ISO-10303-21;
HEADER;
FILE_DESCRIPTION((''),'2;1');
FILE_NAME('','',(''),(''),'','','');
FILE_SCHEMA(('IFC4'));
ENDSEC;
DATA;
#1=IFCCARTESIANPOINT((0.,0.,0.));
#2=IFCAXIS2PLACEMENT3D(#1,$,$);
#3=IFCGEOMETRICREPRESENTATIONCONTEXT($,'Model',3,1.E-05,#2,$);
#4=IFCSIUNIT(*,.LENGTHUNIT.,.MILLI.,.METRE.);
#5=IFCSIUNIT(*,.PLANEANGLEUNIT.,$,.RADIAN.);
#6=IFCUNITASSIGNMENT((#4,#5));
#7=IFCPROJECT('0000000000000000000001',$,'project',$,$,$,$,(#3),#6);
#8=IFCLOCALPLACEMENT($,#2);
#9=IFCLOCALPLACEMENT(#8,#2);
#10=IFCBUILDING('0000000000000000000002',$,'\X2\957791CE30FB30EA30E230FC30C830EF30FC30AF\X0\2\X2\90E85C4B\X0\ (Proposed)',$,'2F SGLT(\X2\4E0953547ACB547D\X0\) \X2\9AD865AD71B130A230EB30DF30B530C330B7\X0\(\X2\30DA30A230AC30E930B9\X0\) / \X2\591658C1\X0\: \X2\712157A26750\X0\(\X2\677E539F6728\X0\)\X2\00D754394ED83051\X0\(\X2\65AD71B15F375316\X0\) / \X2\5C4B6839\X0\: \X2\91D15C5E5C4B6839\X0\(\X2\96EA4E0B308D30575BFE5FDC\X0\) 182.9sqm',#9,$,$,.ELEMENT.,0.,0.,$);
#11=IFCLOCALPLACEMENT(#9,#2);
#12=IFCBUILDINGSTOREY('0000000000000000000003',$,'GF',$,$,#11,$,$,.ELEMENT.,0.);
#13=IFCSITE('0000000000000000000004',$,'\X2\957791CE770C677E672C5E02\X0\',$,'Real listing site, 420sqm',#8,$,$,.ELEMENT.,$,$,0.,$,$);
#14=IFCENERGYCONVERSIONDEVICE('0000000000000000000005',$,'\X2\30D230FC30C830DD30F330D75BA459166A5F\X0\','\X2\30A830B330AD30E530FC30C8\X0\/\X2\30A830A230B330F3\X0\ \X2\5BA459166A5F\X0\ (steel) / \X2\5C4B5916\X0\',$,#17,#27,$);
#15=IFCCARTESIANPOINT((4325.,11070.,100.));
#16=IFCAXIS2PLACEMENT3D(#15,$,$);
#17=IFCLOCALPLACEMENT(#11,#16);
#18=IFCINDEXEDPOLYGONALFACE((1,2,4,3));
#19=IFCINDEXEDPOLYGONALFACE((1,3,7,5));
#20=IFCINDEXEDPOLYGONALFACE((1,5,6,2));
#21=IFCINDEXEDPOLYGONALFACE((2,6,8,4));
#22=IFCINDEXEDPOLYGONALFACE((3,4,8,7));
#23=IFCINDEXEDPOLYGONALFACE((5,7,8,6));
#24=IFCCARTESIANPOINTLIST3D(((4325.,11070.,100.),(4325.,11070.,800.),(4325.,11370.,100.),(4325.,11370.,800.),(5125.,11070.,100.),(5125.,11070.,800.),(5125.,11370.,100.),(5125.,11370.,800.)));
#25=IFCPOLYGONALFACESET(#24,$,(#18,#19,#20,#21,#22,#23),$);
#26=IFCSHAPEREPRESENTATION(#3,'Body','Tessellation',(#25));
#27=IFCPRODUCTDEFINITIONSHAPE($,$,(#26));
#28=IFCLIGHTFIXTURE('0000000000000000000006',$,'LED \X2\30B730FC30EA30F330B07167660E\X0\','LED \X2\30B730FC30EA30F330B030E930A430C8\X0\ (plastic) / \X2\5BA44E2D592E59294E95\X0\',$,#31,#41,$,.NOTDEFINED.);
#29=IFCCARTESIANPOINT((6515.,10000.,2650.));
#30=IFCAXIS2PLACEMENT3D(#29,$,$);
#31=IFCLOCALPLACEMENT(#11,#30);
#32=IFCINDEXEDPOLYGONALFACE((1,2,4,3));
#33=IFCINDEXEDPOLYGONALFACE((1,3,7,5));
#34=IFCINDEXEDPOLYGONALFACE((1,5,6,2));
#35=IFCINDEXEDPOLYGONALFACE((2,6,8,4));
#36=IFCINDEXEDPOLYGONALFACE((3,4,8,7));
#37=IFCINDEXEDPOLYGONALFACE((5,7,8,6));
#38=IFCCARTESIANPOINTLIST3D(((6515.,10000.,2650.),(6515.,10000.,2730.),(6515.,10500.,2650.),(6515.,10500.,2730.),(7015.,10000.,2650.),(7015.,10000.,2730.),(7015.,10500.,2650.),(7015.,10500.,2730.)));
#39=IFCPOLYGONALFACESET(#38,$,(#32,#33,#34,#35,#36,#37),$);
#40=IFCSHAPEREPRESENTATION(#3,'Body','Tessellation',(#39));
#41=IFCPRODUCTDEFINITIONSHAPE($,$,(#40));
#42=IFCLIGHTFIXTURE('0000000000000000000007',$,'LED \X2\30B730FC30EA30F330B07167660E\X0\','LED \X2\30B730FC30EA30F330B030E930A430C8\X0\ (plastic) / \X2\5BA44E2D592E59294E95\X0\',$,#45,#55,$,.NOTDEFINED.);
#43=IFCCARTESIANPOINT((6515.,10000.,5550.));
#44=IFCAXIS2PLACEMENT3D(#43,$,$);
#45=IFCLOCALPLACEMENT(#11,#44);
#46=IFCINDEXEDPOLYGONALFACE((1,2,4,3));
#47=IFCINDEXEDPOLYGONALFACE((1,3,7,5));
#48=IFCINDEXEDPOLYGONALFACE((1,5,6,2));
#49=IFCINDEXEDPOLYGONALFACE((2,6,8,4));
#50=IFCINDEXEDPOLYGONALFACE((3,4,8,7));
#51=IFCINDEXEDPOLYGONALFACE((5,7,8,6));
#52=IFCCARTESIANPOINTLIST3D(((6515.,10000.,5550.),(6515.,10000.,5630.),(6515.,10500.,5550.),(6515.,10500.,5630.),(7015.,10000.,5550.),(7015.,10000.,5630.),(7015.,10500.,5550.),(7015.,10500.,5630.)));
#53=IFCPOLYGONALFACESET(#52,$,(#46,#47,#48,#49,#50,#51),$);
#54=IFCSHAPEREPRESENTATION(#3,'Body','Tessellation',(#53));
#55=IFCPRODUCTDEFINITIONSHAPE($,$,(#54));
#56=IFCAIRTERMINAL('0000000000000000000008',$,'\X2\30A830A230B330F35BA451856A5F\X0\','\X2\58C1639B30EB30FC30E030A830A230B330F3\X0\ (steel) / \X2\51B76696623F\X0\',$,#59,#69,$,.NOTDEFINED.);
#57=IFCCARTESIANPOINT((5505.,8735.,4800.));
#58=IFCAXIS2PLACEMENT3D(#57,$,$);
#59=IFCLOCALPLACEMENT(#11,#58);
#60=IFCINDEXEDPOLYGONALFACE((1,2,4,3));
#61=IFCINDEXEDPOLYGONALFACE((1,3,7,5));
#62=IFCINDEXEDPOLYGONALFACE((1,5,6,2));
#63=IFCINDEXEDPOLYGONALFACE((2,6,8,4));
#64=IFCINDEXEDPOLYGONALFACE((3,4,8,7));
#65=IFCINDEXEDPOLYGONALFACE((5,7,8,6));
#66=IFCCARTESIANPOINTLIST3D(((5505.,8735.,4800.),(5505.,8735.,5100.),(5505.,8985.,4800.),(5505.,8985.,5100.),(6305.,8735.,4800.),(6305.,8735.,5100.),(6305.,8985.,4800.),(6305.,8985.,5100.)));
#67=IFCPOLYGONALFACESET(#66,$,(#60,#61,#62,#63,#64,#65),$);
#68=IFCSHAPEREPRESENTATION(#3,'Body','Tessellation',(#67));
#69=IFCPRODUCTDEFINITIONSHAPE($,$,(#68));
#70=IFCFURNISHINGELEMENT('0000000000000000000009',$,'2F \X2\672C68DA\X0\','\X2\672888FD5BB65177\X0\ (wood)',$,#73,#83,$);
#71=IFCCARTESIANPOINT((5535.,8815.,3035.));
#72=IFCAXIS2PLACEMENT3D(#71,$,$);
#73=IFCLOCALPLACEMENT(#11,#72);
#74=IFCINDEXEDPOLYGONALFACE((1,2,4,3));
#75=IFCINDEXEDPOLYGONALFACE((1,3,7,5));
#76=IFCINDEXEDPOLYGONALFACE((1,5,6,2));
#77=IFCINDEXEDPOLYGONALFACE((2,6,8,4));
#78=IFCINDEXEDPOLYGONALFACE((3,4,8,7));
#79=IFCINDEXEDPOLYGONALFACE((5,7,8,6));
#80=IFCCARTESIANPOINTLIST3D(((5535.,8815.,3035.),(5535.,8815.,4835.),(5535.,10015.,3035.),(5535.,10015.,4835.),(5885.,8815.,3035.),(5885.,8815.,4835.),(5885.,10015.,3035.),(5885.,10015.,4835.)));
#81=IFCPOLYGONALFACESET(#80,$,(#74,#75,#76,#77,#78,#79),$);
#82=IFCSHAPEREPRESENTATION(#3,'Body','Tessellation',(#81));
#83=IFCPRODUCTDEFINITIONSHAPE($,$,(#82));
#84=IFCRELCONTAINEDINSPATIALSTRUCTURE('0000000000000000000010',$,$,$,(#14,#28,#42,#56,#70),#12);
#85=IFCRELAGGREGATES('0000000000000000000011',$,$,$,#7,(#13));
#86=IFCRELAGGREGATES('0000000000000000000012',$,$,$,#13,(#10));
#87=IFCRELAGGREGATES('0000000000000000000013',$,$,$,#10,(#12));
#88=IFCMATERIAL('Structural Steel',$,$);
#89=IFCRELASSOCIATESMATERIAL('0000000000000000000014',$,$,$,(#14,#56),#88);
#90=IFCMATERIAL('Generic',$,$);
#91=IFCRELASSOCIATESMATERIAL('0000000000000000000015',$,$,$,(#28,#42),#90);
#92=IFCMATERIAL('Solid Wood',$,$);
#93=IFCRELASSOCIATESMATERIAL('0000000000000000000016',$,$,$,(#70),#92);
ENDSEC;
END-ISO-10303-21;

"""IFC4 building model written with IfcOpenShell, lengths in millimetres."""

from ifc_helpers import new_model, si_unit, frame, frame_2d, origin, place, context, project, spatial, rectangle, extrude, material, element, save


model = new_model("IFC4")

# Units and contexts
model_context = context("Model", 3, precision=1e-05, world=origin())
ifc_project = project(units=[si_unit("LENGTHUNIT", "METRE", prefix="MILLI"), si_unit("PLANEANGLEUNIT", "RADIAN")], contexts=[model_context])

# Site, building, storey
site_placement = place(None, origin())
site = spatial("IfcSite", under=ifc_project, at=site_placement, Name="長野県松本市", ObjectType="Real listing site, 420sqm", CompositionType="ELEMENT", RefElevation=0.0)
building_placement = place(site_placement, origin())
building = spatial("IfcBuilding", under=site, at=building_placement, Name="長野・リモートワーク2部屋 (Proposed)", ObjectType="2F SGLT(三協立命) 高断熱アルミサッシ(ペアガラス) / 外壁: 無垢材(松原木)×吹付け(断熱強化) / 屋根: 金属屋根(雪下ろし対応) 182.9sqm", CompositionType="ELEMENT", ElevationOfRefHeight=0.0, ElevationOfTerrain=0.0)
storey_placement = place(building_placement, origin())
storey = spatial("IfcBuildingStorey", under=building, at=storey_placement, Name="GF", CompositionType="ELEMENT", Elevation=0.0)

# Shared definitions
ifc_material_1 = material(Name="Solid Wood")

# Shared definitions
ifc_material_2 = material(Name="Structural Steel")

# Shared definitions
ifc_material_3 = material(Name="Generic")

# Energy conversion device
energy_conversion_device_placement = place(storey_placement, frame((4325.0, 11070.0, 100.0)))
element("IfcEnergyConversionDevice", 1, at=energy_conversion_device_placement, inside=storey, material=ifc_material_2, Name="ヒートポンプ室外機", Description="エコキュート/エアコン 室外機 (steel) / 屋外", context=model_context, shape_type="SweptSolid", body=[
    extrude(rectangle(XDim=800.0, YDim=300.0, at=frame_2d((400.0, 150.0))), frame((4325.0, 11070.0, 100.0)), (0.0, 0.0, 1.0), 700.0),
])

# Light fixtures
light_fixture_1_placement = place(storey_placement, frame((6515.0, 10000.0, 2650.0)))
element("IfcLightFixture", 2, at=light_fixture_1_placement, inside=storey, material=ifc_material_3, Name="LED シーリング照明", Description="LED シーリングライト (plastic) / 室中央天井", PredefinedType="NOTDEFINED", context=model_context, shape_type="SweptSolid", body=[
    extrude(rectangle(XDim=500.0, YDim=500.0, at=frame_2d((250.0, 250.0))), frame((6515.0, 10000.0, 2650.0)), (0.0, 0.0, 1.0), 80.0),
])
light_fixture_2_placement = place(storey_placement, frame((6515.0, 10000.0, 5550.0)))
element("IfcLightFixture", 3, at=light_fixture_2_placement, inside=storey, material=ifc_material_3, Name="LED シーリング照明", Description="LED シーリングライト (plastic) / 室中央天井", PredefinedType="NOTDEFINED", context=model_context, shape_type="SweptSolid", body=[
    extrude(rectangle(XDim=500.0, YDim=500.0, at=frame_2d((250.0, 250.0))), frame((6515.0, 10000.0, 5550.0)), (0.0, 0.0, 1.0), 80.0),
])

# Air terminal
air_terminal_placement = place(storey_placement, frame((5505.0, 8735.0, 4800.0)))
element("IfcAirTerminal", 4, at=air_terminal_placement, inside=storey, material=ifc_material_2, Name="エアコン室内機", Description="壁掛ルームエアコン (steel) / 冷暖房", PredefinedType="NOTDEFINED", context=model_context, shape_type="SweptSolid", body=[
    extrude(rectangle(XDim=800.0, YDim=250.0, at=frame_2d((400.0, 125.0))), frame((5505.0, 8735.0, 4800.0)), (0.0, 0.0, 1.0), 300.0),
])

# Furnishing element
furnishing_placement = place(storey_placement, frame((5535.0, 8815.0, 3035.0)))
element("IfcFurnishingElement", 5, at=furnishing_placement, inside=storey, material=ifc_material_1, Name="2F 本棚", Description="木製家具 (wood)", context=model_context, shape_type="SweptSolid", body=[
    extrude(rectangle(XDim=350.0, YDim=1200.0, at=frame_2d((175.0, 600.0))), frame((5535.0, 8815.0, 3035.0)), (0.0, 0.0, 1.0), 1800.0),
])

save(model, "model.ifc")
